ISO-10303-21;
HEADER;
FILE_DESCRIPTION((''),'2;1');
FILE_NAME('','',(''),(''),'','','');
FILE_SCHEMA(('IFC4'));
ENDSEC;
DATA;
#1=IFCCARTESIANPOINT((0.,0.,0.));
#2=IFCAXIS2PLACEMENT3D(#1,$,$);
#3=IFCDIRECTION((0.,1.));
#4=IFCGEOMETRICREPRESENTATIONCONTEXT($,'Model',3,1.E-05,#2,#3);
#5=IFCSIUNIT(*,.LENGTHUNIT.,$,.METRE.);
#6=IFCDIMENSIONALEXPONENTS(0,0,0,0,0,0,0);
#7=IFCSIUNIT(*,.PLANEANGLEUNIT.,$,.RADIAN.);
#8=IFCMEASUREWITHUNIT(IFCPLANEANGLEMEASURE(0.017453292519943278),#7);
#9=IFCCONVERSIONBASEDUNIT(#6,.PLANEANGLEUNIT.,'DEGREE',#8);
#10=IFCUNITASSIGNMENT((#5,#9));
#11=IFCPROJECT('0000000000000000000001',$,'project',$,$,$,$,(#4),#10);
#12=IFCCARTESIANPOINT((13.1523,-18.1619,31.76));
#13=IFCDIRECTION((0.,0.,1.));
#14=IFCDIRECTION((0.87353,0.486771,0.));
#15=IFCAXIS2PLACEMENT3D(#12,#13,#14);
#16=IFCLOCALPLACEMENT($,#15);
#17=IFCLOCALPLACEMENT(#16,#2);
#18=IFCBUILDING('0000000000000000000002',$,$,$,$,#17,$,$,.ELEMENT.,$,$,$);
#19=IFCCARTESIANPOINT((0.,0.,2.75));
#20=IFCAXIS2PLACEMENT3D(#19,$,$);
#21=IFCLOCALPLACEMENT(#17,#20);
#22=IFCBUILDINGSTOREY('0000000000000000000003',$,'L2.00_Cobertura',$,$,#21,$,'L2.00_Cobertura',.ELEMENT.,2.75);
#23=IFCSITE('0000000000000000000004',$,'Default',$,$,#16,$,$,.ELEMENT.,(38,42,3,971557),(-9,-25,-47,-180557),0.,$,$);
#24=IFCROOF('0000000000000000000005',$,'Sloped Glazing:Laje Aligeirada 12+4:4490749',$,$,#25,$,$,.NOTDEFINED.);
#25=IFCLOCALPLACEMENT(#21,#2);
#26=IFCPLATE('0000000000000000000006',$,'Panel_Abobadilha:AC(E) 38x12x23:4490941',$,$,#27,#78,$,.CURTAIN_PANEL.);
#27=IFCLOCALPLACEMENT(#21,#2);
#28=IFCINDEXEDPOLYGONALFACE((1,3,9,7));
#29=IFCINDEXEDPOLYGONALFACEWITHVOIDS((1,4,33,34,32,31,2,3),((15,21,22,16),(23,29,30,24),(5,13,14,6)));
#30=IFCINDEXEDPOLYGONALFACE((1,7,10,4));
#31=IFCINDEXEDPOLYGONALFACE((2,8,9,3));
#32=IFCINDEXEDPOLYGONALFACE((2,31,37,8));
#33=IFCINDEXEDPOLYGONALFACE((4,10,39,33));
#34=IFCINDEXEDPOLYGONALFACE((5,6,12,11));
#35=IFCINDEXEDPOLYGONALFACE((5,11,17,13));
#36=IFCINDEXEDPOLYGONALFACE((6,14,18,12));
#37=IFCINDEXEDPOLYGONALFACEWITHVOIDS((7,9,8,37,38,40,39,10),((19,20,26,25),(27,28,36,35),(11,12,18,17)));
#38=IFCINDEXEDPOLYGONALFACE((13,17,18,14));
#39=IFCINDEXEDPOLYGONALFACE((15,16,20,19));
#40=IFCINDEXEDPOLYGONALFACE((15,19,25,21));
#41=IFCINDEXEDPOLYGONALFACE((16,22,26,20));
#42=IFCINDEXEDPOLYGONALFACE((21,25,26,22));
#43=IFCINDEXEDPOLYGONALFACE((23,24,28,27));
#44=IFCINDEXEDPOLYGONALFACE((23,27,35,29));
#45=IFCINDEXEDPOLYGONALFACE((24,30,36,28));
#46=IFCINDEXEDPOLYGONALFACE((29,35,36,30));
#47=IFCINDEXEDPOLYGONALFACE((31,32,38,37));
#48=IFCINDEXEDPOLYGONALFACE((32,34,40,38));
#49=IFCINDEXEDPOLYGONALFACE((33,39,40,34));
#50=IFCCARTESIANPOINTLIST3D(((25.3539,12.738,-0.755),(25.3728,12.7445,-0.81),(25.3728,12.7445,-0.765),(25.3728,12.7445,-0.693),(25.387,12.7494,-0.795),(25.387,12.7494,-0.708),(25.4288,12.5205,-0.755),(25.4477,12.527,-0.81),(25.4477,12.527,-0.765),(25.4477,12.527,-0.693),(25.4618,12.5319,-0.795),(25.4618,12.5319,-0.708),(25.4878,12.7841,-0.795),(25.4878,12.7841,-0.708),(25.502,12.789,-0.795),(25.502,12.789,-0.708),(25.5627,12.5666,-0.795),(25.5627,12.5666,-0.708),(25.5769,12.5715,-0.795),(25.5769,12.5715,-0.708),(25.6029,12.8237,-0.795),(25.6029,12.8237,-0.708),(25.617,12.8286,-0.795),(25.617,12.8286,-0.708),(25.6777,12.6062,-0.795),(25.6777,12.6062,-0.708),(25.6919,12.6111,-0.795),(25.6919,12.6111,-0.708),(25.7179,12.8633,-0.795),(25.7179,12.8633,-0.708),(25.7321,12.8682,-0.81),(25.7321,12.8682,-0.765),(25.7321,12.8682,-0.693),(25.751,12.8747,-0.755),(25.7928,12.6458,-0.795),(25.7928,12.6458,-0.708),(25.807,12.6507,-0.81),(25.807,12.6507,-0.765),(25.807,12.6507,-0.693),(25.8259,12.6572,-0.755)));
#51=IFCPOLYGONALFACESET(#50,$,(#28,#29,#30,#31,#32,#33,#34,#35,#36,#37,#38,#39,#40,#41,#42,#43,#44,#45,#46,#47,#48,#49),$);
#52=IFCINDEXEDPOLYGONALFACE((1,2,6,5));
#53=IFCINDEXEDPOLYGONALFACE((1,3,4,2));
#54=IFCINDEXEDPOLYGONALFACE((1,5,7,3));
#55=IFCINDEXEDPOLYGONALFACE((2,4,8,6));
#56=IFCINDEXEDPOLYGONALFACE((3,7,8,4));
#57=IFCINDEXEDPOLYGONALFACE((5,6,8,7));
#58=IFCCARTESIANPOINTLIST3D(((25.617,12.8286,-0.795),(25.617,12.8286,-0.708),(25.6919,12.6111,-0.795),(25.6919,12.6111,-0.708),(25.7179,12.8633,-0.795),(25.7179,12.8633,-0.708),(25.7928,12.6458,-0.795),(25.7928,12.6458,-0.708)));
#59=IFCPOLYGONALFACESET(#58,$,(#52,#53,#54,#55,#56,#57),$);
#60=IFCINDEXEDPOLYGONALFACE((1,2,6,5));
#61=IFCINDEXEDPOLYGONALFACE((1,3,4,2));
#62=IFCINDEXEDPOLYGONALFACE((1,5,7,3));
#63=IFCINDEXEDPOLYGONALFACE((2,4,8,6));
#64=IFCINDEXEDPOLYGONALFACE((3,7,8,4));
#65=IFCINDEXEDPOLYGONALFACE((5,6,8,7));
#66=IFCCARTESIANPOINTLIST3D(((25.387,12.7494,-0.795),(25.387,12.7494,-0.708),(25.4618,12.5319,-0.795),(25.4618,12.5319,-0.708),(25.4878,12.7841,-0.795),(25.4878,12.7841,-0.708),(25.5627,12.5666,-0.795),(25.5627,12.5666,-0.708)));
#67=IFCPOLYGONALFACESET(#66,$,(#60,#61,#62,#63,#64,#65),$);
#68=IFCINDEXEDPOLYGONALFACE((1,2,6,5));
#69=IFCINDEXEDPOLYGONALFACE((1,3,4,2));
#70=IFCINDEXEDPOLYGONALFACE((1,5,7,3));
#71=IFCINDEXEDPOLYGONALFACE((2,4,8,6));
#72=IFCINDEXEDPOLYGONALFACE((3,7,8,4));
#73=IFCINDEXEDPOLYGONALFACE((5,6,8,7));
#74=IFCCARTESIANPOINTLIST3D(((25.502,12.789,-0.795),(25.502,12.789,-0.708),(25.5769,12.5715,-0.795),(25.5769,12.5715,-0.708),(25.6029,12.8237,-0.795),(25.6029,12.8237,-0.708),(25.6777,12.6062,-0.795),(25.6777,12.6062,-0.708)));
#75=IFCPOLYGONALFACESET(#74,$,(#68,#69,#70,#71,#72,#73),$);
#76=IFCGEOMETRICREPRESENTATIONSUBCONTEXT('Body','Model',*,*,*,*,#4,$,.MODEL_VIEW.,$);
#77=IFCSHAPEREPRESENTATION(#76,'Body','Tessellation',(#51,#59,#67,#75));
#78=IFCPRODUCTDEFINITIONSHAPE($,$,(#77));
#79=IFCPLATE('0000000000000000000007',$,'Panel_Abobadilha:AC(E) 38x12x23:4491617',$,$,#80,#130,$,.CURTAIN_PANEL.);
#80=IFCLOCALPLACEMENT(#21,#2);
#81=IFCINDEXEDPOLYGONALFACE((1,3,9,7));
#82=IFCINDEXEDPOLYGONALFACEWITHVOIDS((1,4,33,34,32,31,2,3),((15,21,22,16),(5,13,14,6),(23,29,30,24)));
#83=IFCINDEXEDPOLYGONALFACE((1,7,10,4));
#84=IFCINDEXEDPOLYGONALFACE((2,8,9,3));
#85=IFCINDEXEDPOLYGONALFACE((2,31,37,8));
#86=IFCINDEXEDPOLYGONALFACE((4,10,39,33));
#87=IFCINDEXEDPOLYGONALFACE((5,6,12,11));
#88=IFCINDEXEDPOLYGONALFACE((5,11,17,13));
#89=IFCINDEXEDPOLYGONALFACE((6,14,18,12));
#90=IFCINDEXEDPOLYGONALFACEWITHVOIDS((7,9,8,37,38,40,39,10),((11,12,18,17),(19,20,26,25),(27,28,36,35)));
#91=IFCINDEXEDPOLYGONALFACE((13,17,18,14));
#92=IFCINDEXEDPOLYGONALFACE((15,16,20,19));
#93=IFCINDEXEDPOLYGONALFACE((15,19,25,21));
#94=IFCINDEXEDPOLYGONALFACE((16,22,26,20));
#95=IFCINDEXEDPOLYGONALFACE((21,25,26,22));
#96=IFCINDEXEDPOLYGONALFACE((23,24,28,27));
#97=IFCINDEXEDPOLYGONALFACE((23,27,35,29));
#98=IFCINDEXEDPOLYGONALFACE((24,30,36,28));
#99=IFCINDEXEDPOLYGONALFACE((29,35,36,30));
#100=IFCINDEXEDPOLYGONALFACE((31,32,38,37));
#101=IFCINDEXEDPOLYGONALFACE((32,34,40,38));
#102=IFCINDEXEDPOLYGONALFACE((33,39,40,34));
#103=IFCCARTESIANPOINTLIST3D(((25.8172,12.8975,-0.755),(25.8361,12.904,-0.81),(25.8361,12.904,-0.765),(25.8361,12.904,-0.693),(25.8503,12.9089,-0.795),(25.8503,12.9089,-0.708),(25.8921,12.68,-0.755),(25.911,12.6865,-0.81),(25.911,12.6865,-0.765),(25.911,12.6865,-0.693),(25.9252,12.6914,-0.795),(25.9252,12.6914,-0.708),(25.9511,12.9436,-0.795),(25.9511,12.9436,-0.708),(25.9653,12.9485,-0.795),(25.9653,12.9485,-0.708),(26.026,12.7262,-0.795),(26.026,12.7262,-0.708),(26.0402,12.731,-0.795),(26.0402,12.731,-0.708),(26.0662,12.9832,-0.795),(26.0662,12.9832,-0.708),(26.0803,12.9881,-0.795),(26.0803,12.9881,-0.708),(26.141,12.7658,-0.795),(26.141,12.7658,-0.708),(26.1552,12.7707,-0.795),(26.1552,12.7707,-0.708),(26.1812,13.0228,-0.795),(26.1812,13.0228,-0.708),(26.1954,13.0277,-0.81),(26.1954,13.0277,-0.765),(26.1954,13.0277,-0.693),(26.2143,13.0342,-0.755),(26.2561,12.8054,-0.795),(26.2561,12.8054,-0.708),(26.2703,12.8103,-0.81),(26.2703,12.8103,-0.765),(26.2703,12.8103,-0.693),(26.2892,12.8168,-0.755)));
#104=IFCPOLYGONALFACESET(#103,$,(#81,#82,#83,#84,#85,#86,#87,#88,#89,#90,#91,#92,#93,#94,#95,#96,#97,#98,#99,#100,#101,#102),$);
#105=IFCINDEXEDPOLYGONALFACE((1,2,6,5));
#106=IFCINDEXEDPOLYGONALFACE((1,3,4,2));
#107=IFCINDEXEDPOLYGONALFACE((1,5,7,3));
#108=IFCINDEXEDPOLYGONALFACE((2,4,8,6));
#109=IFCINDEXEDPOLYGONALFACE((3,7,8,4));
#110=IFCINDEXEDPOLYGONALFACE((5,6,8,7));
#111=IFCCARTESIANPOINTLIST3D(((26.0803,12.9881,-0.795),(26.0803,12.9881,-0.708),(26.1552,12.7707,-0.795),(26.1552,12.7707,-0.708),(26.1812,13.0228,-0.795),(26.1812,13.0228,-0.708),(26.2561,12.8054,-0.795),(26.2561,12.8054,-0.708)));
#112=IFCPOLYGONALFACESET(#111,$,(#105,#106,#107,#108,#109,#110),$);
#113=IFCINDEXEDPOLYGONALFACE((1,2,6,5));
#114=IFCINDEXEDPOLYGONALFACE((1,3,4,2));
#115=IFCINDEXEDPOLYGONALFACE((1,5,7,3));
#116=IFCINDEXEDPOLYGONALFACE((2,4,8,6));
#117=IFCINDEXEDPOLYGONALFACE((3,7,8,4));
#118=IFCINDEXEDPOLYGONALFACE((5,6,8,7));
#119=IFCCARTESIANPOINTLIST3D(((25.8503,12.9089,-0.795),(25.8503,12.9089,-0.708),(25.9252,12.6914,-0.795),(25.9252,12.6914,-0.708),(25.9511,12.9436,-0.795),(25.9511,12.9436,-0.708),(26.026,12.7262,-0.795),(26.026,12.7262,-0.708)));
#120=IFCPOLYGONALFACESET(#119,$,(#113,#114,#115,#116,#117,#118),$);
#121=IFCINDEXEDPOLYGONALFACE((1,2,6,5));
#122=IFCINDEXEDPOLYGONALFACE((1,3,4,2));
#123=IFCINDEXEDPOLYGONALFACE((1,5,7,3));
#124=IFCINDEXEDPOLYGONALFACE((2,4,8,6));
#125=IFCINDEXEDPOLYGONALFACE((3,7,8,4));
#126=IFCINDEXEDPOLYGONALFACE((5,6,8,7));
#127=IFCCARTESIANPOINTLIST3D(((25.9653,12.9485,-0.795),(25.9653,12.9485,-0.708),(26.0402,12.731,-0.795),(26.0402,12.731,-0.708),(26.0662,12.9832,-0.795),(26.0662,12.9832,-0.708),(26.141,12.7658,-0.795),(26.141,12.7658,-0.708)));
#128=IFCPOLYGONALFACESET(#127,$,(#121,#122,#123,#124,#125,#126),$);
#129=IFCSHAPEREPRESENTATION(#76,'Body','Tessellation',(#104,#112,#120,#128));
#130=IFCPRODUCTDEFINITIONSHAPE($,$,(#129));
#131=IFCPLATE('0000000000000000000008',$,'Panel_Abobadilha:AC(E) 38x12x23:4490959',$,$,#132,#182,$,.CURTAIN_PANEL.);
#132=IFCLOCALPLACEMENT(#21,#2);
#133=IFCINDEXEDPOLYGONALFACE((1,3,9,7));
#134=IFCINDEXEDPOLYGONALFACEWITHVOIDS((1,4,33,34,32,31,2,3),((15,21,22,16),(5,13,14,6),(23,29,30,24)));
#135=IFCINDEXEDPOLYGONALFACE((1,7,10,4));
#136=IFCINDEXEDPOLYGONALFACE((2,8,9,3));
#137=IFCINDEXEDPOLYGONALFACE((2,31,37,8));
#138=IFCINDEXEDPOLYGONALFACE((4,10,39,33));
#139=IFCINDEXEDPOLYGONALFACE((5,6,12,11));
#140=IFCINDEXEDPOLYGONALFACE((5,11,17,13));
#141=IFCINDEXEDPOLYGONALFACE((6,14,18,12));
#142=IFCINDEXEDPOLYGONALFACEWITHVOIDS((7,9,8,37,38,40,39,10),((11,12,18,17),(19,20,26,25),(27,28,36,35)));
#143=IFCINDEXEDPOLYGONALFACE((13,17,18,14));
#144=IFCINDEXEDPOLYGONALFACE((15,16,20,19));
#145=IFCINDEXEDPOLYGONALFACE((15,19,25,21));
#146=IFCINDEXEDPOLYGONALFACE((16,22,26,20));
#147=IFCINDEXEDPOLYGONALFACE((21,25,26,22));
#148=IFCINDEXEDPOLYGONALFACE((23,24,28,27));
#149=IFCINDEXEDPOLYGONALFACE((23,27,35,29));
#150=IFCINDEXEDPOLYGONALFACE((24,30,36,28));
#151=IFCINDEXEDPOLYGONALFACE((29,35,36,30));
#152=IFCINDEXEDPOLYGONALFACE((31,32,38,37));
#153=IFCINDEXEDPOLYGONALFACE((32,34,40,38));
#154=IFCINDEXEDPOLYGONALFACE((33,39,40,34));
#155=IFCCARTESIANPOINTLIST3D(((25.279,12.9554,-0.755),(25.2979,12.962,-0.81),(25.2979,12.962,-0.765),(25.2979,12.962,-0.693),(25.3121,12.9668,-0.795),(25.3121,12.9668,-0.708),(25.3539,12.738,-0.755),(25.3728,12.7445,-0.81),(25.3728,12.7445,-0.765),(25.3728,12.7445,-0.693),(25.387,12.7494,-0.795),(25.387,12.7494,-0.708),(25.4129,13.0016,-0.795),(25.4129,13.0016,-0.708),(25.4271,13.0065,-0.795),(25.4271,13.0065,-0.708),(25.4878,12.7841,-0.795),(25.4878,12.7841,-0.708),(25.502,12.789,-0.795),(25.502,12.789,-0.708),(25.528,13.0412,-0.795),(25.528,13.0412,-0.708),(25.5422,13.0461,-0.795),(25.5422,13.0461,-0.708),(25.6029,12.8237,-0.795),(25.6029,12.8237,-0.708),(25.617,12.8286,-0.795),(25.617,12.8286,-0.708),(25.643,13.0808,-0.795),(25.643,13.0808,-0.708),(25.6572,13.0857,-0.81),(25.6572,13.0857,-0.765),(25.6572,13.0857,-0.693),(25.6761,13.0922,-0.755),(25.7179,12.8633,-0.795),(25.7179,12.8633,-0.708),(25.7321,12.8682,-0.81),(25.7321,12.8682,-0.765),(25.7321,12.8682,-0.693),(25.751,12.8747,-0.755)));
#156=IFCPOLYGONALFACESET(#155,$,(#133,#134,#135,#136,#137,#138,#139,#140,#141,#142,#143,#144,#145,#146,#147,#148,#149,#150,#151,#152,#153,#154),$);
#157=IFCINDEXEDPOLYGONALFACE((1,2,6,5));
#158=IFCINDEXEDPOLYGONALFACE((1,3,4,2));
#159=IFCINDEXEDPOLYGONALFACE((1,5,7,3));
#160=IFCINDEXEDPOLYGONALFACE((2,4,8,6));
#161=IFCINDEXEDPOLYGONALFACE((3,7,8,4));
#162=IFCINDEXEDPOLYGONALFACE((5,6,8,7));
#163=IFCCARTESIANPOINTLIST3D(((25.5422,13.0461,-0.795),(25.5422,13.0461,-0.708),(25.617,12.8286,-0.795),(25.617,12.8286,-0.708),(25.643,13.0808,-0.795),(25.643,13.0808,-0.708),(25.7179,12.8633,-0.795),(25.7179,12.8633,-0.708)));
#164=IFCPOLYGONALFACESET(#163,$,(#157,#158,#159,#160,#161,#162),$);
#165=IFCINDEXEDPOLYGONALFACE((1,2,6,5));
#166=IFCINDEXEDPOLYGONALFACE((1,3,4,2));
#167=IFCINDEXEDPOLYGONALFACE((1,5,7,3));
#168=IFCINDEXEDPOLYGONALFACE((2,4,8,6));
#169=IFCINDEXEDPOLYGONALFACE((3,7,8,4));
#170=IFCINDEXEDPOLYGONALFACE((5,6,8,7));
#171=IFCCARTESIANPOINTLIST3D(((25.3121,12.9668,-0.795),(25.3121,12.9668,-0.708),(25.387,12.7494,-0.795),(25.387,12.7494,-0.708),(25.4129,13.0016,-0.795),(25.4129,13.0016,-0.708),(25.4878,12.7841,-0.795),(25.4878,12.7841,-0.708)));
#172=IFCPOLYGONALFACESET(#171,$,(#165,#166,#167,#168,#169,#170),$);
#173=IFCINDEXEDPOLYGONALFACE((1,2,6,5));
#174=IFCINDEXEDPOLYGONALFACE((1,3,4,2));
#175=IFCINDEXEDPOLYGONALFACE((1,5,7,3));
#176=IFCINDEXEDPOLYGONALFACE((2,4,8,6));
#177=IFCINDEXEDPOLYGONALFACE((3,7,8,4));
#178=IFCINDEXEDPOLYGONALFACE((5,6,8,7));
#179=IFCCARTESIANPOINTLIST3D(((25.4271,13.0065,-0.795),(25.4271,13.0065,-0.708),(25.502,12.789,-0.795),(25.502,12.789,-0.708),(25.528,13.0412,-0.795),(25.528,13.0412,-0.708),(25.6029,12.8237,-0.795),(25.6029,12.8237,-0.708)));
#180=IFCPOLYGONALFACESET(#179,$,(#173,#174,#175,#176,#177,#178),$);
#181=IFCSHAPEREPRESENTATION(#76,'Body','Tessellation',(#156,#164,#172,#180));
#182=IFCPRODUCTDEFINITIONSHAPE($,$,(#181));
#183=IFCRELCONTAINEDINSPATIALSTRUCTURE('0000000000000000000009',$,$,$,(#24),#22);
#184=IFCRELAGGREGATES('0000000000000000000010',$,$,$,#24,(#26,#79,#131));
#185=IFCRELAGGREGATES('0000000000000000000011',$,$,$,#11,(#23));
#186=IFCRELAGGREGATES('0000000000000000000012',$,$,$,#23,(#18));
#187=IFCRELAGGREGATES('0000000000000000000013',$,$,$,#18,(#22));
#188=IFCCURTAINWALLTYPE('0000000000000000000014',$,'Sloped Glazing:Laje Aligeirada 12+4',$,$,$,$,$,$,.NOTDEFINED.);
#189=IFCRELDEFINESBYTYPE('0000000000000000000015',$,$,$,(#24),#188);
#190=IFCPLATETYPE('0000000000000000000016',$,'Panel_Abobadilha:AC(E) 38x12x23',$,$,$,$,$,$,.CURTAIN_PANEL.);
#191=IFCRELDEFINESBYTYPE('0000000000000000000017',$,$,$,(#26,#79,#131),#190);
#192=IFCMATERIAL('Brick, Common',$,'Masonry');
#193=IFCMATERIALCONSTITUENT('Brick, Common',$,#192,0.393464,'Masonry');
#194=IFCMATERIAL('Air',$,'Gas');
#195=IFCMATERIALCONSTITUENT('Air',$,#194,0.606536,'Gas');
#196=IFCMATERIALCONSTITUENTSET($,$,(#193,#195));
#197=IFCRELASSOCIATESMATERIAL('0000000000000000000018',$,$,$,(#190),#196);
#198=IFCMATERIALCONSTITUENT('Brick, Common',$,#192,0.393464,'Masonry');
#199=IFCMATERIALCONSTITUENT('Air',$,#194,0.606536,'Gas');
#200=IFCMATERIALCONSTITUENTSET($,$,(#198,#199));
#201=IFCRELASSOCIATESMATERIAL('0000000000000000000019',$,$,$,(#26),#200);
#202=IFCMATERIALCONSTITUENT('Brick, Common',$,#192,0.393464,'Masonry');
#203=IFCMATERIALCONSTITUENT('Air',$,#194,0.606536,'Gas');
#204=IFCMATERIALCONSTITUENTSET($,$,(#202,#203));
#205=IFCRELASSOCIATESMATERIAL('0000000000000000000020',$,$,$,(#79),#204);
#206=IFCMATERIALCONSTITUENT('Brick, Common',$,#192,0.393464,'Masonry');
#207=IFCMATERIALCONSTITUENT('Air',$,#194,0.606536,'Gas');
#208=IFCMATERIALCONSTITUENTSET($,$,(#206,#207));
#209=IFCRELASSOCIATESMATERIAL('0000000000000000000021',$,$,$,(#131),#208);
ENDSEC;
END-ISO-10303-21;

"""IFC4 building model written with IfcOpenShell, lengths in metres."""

from ifc_helpers import new_model, entity, si_unit, converted_unit, direction, frame, origin, place, context, subcontext, project, spatial, indexed_curve, outline, extrude, source, transform, mapped, material, constituent, constituent_set, type_object, type_shapes, element, aggregate, save


model = new_model("IFC4")

# Units and contexts
model_context = context("Model", 3, precision=1e-05, world=origin(), true_north=direction((0.0, 1.0)))
body_context = subcontext(model_context, "Body", "Model", "MODEL_VIEW")
ifc_project = project(units=[si_unit("LENGTHUNIT", "METRE"), converted_unit("PLANEANGLEUNIT", "DEGREE", entity("IfcPlaneAngleMeasure", 0.017453292519943278), si_unit("PLANEANGLEUNIT", "RADIAN"), dimensions=[0, 0, 0, 0, 0, 0, 0])], contexts=[model_context])

# Site, building, storey
site_placement = place(None, frame((13.1523, -18.1619, 31.76), z_axis=(0.0, 0.0, 1.0), x_axis=(0.87353, 0.486771, 0.0)))
site = spatial("IfcSite", under=ifc_project, at=site_placement, Name="Default", CompositionType="ELEMENT", RefLatitude=(38, 42, 3, 971557), RefLongitude=(-9, -25, -47, -180557), RefElevation=0.0)
building_placement = place(site_placement, origin())
building = spatial("IfcBuilding", under=site, at=building_placement, CompositionType="ELEMENT")
storey_placement = place(building_placement, frame((0.0, 0.0, 2.75)))
storey = spatial("IfcBuildingStorey", under=building, at=storey_placement, Name="L2.00_Cobertura", LongName="L2.00_Cobertura", CompositionType="ELEMENT", Elevation=2.75)

# Roof, plates
curtain_wall_type = type_object("IfcCurtainWallType", Name="Sloped Glazing:Laje Aligeirada 12+4", PredefinedType="NOTDEFINED")
roof_placement = place(storey_placement, frame((0.0, 0.0, -2.75)))
roof = element("IfcRoof", 1, at=roof_placement, inside=storey, type_object=curtain_wall_type, Name="Sloped Glazing:Laje Aligeirada 12+4:4490749", PredefinedType="NOTDEFINED")
ifc_material_1 = material(Name="Brick, Common", Category="Masonry")
ifc_constituent_1 = constituent(ifc_material_1, Name="Brick, Common", Category="Masonry", fraction=0.393464)
ifc_material_2 = material(Name="Air", Category="Gas")
ifc_constituent_2 = constituent(ifc_material_2, Name="Air", Category="Gas", fraction=0.606536)
ifc_constituent_set_1 = constituent_set(constituents=[ifc_constituent_1, ifc_constituent_2])
ifc_constituent_3 = constituent(ifc_material_1, Name="Brick, Common", Category="Masonry", fraction=0.393464)
ifc_constituent_4 = constituent(ifc_material_2, Name="Air", Category="Gas", fraction=0.606536)
ifc_constituent_set_2 = constituent_set(constituents=[ifc_constituent_3, ifc_constituent_4])
plate_type = type_object("IfcPlateType", Name="Panel_Abobadilha:AC(E) 38x12x23", PredefinedType="CURTAIN_PANEL", material=ifc_constituent_set_2)
shared_shape_1 = source(origin(), body_context, "Body", "SweptSolid", [
    extrude(outline(indexed_curve([(-0.19, -0.0543), (0.19, -0.0543), (0.19, -0.0093), (0.21, 0.0007), (0.19, 0.0628), (-0.19, 0.0628), (-0.21, 0.0007), (-0.19, -0.0093), (-0.19, -0.0543)], self_intersect=False), holes=[indexed_curve([(-0.0683, 0.0477), (-0.0683, -0.0393), (-0.175, -0.0393), (-0.175, 0.0477), (-0.0683, 0.0477)], self_intersect=False), indexed_curve([(0.0533, 0.0477), (0.0533, -0.0393), (-0.0533, -0.0393), (-0.0533, 0.0477), (0.0533, 0.0477)], self_intersect=False), indexed_curve([(0.175, 0.0477), (0.175, -0.0393), (0.0683, -0.0393), (0.0683, 0.0477), (0.175, 0.0477)], self_intersect=False)]), frame((0.0, 0.0543, 0.0)), (0.0, 0.0, 1.0), 0.23),
    extrude(outline(indexed_curve([(-0.0533, -0.0435), (0.0533, -0.0435), (0.0533, 0.0435), (-0.0533, 0.0435), (-0.0533, -0.0435)], self_intersect=False)), frame((0.1217, 0.0585, 0.0), z_axis=(0.0, 0.0, 1.0), x_axis=(-1.0, 0.0, 0.0)), (0.0, 0.0, 1.0), 0.23),
    extrude(outline(indexed_curve([(-0.0533, -0.0435), (0.0533, -0.0435), (0.0533, 0.0435), (-0.0533, 0.0435), (-0.0533, -0.0435)], self_intersect=False)), frame((-0.1217, 0.0585, 0.0), z_axis=(0.0, 0.0, 1.0), x_axis=(-1.0, 0.0, 0.0)), (0.0, 0.0, 1.0), 0.23),
    extrude(outline(indexed_curve([(-0.0533, -0.0435), (0.0533, -0.0435), (0.0533, 0.0435), (-0.0533, 0.0435), (-0.0533, -0.0435)], self_intersect=False)), frame((0.0, 0.0585, 0.0), z_axis=(0.0, 0.0, 1.0), x_axis=(-1.0, 0.0, 0.0)), (0.0, 0.0, 1.0), 0.23),
])
type_shapes(plate_type, [shared_shape_1])
plate_1_placement = place(roof_placement, frame((25.5524, 12.8063, 1.94), z_axis=(0.325568, -0.945519, 0.0), x_axis=(0.945519, 0.325568, 0.0)))
plate_1 = element("IfcPlate", 2, at=plate_1_placement, type_object=plate_type, material=ifc_constituent_set_1, Name="Panel_Abobadilha:AC(E) 38x12x23:4490941", PredefinedType="CURTAIN_PANEL", context=body_context, shape_type="MappedRepresentation", body=[
    mapped(shared_shape_1, transform((0.0, 0.0, 0.0), scale=1.0)),
])
ifc_constituent_5 = constituent(ifc_material_1, Name="Brick, Common", Category="Masonry", fraction=0.393464)
ifc_constituent_6 = constituent(ifc_material_2, Name="Air", Category="Gas", fraction=0.606536)
ifc_constituent_set_3 = constituent_set(constituents=[ifc_constituent_5, ifc_constituent_6])
plate_2_placement = place(roof_placement, frame((26.0157, 12.9659, 1.94), z_axis=(0.325568, -0.945519, 0.0), x_axis=(0.945519, 0.325568, 0.0)))
plate_2 = element("IfcPlate", 3, at=plate_2_placement, type_object=plate_type, material=ifc_constituent_set_3, Name="Panel_Abobadilha:AC(E) 38x12x23:4491617", PredefinedType="CURTAIN_PANEL", context=body_context, shape_type="MappedRepresentation", body=[
    mapped(shared_shape_1, transform((0.0, 0.0, 0.0), scale=1.0)),
])
ifc_constituent_7 = constituent(ifc_material_1, Name="Brick, Common", Category="Masonry", fraction=0.393464)
ifc_constituent_8 = constituent(ifc_material_2, Name="Air", Category="Gas", fraction=0.606536)
ifc_constituent_set_4 = constituent_set(constituents=[ifc_constituent_7, ifc_constituent_8])
plate_3_placement = place(roof_placement, frame((25.4776, 13.0238, 1.94), z_axis=(0.325568, -0.945519, 0.0), x_axis=(0.945519, 0.325568, 0.0)))
plate_3 = element("IfcPlate", 4, at=plate_3_placement, type_object=plate_type, material=ifc_constituent_set_4, Name="Panel_Abobadilha:AC(E) 38x12x23:4490959", PredefinedType="CURTAIN_PANEL", context=body_context, shape_type="MappedRepresentation", body=[
    mapped(shared_shape_1, transform((0.0, 0.0, 0.0), scale=1.0)),
])
aggregate(roof, [plate_1, plate_2, plate_3])

save(model, "model.ifc")
